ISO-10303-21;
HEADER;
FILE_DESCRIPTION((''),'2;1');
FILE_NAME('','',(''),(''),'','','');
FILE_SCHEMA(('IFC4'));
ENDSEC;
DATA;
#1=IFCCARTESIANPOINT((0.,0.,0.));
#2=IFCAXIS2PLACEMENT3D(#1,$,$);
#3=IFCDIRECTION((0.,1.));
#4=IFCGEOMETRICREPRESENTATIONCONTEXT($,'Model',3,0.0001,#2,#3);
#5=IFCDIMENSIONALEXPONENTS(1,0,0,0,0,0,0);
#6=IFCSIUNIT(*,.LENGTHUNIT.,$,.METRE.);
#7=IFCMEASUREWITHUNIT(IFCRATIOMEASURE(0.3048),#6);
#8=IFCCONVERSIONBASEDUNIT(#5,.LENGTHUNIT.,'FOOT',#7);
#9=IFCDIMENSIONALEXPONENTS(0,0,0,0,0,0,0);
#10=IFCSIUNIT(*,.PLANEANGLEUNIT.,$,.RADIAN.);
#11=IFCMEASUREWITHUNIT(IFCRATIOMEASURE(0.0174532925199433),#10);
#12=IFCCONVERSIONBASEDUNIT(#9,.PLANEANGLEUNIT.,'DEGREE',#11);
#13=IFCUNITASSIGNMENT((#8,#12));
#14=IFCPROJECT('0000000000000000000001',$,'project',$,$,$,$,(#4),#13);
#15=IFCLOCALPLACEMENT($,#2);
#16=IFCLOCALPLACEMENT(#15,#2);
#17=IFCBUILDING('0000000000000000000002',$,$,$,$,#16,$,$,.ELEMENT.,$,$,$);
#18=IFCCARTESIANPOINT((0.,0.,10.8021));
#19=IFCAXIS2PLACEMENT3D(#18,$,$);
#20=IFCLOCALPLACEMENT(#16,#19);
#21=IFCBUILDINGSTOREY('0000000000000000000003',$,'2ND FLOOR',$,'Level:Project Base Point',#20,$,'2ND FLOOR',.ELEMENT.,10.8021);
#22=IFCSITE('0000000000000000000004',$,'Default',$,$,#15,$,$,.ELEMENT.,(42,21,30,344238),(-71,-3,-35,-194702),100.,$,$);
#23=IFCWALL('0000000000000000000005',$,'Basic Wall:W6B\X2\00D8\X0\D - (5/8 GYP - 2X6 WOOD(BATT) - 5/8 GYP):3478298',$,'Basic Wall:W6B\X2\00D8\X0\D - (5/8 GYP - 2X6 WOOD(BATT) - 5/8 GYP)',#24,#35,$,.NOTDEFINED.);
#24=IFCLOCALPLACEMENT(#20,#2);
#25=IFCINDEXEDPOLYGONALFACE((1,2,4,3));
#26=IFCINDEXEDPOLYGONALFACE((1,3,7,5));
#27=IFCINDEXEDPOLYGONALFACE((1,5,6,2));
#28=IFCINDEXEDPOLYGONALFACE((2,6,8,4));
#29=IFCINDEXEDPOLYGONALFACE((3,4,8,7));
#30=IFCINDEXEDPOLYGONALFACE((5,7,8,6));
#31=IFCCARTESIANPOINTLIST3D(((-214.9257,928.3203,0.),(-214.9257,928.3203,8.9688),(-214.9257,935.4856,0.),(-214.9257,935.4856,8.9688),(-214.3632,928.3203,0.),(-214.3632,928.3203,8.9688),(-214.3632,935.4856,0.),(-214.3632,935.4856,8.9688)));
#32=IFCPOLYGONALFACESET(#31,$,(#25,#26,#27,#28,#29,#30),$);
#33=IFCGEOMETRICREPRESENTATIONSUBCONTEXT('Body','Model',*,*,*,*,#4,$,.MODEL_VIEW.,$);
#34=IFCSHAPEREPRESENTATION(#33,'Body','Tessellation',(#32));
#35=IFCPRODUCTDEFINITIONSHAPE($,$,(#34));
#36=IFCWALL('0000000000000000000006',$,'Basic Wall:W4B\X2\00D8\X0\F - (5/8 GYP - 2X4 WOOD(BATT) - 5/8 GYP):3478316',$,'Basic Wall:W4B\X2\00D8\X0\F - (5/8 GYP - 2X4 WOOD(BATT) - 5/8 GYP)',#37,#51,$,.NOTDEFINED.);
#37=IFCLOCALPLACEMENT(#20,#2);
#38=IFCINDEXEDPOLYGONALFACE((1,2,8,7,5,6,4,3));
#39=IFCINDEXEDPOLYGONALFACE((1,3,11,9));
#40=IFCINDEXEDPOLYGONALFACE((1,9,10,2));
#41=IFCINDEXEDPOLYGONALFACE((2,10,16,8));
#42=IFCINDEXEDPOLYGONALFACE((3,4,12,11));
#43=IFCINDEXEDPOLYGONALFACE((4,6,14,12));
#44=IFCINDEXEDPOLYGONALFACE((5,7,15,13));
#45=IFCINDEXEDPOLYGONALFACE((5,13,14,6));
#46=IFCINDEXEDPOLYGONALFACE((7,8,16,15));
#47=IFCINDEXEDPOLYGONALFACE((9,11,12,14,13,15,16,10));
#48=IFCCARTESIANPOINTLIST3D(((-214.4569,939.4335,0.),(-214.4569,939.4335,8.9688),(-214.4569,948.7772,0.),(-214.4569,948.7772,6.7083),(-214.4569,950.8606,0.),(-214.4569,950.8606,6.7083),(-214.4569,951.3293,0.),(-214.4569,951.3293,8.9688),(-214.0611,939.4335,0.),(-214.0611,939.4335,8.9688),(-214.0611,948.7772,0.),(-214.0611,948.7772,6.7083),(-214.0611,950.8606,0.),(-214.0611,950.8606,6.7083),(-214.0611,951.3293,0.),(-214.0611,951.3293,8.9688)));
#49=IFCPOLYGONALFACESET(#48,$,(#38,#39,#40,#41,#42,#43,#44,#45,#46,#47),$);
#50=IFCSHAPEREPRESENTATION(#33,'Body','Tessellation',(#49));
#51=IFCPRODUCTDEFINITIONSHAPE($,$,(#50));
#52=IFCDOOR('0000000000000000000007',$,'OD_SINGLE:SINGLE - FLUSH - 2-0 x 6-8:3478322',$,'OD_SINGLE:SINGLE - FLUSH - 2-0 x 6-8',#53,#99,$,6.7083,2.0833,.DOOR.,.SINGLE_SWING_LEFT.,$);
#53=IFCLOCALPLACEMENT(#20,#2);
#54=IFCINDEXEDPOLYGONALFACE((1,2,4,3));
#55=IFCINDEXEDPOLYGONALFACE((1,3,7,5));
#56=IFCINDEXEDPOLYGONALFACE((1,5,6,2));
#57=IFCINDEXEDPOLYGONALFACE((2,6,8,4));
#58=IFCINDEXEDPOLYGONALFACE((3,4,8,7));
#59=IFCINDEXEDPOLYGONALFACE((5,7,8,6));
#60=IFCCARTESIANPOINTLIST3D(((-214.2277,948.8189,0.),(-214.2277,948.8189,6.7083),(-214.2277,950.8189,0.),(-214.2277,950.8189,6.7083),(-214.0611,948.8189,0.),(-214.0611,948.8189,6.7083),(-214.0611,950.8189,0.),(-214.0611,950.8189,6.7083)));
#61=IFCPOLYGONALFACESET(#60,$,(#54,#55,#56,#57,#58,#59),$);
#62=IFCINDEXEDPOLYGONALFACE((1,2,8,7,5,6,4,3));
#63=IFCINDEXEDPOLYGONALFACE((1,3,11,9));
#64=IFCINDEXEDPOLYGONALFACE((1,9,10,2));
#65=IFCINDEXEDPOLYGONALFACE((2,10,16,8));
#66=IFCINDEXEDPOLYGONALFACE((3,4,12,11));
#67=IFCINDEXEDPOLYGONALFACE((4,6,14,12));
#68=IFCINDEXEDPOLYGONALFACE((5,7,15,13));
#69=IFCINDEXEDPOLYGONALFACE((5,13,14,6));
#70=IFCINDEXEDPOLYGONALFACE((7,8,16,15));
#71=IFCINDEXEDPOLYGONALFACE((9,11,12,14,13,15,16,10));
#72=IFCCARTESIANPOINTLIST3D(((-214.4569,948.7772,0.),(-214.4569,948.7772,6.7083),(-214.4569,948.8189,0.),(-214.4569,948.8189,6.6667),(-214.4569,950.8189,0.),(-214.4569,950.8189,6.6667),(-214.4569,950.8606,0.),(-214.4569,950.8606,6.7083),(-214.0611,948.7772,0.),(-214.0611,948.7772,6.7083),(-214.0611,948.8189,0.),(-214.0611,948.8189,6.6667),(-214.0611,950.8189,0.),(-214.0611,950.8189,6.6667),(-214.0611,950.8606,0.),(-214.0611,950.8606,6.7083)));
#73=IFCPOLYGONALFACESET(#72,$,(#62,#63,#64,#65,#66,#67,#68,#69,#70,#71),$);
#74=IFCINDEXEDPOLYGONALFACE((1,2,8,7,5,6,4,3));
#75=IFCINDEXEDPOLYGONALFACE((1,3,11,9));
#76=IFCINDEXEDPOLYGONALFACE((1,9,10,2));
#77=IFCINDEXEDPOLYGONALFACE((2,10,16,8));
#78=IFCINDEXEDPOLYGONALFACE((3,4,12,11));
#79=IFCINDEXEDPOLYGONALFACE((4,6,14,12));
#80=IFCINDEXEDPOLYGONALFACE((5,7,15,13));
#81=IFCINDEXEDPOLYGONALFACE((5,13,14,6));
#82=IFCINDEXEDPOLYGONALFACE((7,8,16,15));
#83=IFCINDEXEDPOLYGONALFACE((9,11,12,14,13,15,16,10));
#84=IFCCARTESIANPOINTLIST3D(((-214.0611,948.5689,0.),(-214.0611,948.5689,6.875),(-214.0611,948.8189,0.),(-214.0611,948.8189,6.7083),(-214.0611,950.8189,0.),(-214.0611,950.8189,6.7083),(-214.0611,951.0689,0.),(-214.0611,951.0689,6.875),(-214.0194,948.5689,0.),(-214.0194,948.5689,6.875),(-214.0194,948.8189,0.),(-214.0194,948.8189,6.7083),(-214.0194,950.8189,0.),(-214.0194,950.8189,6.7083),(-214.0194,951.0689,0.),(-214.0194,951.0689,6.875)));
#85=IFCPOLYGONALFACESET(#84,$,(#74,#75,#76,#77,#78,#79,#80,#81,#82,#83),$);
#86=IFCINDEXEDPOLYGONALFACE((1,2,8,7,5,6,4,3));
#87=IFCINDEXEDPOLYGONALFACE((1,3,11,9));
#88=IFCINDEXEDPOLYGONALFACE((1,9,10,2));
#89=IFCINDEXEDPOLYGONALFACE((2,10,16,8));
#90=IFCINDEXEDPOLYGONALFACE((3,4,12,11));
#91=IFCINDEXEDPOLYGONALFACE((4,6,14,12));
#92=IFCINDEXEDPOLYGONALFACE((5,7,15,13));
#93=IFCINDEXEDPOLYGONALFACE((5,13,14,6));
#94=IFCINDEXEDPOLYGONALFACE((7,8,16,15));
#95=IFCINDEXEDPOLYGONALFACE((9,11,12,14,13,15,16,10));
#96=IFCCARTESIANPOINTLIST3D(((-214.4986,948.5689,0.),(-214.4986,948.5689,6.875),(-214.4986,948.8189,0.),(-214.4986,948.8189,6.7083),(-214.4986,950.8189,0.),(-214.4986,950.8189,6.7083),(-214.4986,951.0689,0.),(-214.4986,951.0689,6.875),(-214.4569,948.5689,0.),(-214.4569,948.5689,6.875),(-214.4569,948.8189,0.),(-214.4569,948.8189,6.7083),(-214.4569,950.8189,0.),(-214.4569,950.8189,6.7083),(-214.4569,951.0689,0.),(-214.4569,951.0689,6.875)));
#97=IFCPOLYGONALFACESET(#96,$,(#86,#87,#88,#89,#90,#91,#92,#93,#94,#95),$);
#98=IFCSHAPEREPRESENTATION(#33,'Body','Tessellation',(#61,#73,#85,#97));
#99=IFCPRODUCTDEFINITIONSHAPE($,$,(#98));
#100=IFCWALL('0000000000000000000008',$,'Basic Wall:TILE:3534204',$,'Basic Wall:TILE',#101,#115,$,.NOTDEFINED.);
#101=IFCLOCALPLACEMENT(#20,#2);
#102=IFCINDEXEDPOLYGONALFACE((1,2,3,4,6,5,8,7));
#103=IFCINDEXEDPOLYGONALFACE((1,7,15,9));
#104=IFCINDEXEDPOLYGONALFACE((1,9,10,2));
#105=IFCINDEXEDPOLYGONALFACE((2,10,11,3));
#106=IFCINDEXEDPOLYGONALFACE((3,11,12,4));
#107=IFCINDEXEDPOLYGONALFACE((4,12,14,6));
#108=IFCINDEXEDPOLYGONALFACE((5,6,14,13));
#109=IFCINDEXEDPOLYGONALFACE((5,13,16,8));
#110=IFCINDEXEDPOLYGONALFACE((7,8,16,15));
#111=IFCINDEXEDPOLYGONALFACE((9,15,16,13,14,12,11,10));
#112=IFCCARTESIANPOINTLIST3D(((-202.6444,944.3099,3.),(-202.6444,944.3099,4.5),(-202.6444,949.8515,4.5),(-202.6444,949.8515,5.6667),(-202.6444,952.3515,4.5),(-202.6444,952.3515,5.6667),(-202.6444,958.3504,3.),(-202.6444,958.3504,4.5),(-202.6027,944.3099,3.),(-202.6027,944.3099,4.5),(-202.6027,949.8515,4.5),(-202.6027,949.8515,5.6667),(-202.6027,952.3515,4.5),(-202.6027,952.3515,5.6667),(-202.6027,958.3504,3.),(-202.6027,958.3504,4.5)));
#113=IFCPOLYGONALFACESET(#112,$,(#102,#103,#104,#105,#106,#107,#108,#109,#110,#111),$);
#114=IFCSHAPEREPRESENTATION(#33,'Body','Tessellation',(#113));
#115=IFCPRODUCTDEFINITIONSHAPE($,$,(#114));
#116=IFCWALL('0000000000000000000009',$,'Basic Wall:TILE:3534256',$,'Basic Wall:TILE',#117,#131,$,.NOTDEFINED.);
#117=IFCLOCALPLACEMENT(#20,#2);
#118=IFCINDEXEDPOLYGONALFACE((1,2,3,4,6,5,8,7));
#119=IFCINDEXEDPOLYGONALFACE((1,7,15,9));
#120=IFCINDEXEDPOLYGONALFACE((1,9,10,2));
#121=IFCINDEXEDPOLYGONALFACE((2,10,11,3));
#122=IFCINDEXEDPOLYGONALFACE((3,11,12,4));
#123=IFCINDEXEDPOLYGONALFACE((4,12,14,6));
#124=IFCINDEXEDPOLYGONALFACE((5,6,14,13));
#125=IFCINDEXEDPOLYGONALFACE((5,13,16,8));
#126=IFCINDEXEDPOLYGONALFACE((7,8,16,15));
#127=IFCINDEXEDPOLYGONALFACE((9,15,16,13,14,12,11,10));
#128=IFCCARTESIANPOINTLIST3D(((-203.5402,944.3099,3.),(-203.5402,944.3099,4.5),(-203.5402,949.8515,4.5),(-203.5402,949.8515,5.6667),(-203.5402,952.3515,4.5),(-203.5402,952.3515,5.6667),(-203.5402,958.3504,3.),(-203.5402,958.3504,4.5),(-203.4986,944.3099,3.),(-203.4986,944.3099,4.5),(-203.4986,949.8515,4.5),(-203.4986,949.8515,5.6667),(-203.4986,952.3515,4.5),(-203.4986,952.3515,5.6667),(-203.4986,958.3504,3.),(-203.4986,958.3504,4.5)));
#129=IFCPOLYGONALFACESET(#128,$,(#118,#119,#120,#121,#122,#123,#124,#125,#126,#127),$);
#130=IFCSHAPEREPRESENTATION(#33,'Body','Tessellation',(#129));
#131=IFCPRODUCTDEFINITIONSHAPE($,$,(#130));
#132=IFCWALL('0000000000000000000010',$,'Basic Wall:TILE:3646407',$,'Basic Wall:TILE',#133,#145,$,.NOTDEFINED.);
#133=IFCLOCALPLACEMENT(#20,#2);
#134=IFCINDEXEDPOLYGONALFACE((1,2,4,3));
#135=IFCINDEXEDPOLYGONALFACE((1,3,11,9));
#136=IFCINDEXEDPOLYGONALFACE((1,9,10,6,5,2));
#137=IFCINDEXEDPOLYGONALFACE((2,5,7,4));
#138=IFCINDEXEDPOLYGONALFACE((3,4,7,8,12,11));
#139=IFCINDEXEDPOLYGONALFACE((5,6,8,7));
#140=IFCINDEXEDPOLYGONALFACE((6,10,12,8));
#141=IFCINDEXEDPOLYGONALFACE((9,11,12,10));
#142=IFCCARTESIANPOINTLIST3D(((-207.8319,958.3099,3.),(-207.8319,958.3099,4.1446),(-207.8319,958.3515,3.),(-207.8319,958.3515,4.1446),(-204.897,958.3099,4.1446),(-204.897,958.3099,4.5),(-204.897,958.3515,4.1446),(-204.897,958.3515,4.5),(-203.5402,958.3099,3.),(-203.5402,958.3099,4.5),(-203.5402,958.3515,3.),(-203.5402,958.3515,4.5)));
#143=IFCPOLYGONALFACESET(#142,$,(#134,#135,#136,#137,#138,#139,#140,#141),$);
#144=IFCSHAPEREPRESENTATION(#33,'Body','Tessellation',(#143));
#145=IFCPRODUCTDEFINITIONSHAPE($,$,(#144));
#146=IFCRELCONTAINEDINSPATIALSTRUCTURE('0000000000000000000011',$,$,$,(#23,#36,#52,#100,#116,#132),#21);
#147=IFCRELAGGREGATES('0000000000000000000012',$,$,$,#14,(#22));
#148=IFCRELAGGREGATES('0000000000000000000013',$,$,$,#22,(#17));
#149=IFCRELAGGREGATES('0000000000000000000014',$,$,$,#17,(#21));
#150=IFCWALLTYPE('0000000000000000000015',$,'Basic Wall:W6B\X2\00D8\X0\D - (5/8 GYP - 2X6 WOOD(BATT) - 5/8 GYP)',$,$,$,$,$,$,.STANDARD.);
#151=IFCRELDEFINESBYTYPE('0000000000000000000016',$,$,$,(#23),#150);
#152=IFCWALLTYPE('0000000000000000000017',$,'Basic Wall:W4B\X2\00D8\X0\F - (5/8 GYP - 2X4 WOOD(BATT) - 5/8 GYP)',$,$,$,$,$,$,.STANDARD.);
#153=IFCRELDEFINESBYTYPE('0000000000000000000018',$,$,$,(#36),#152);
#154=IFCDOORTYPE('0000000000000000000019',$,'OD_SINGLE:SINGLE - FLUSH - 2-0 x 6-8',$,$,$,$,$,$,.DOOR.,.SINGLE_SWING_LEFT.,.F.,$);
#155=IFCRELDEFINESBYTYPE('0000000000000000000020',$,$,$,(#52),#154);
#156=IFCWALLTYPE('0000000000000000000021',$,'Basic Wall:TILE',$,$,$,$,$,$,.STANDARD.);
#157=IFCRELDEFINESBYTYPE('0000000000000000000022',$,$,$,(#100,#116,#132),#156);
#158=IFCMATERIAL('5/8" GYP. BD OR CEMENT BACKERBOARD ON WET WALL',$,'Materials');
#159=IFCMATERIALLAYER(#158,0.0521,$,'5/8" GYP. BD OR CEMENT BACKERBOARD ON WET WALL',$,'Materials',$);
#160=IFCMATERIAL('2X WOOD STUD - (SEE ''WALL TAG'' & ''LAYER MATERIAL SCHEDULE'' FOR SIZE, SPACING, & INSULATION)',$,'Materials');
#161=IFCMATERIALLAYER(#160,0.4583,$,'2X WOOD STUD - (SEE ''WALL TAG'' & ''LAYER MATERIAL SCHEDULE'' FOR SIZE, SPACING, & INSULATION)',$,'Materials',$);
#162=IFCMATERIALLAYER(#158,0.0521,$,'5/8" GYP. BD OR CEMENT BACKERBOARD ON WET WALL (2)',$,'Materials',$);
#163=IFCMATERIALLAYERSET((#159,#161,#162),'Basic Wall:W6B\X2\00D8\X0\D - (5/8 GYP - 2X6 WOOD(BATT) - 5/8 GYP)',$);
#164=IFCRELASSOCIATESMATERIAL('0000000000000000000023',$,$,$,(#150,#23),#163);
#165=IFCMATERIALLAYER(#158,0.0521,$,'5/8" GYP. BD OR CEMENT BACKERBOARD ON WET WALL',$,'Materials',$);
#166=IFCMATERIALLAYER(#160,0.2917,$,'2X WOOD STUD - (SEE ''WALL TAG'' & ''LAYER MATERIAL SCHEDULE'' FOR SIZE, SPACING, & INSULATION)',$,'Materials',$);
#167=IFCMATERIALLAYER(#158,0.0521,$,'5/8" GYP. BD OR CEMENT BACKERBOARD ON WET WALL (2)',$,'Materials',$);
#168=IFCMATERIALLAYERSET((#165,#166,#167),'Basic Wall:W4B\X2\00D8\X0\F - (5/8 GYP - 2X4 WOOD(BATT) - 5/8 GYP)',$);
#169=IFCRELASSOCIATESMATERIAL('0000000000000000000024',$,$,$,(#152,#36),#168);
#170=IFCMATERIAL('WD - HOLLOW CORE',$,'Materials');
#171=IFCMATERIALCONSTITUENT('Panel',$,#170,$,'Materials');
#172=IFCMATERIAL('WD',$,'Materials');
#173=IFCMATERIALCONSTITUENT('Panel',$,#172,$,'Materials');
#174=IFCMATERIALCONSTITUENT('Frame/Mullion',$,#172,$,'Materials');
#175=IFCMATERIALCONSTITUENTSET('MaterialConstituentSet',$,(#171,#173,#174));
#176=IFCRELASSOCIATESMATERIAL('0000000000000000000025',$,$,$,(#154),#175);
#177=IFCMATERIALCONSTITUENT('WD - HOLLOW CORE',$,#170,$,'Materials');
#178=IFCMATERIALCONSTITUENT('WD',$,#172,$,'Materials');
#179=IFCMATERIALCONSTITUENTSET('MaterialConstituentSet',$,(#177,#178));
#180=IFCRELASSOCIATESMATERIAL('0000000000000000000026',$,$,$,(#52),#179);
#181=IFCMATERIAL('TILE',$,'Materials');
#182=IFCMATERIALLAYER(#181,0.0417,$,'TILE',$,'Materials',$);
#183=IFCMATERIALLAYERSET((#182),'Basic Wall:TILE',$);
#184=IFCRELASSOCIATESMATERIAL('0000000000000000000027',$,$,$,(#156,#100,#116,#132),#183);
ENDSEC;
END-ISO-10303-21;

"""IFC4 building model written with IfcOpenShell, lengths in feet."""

from ifc_helpers import new_model, entity, si_unit, converted_unit, direction, frame, frame_2d, origin, origin_2d_with_axis, place, context, subcontext, project, spatial, polyline, rectangle, outline, extrude, source, transform, mapped, material, layer, layer_set, layer_usage, constituent, constituent_set, type_object, type_shapes, element, fill, save


model = new_model("IFC4")

# Units and contexts
model_context = context("Model", 3, precision=0.0001, world=origin(), true_north=direction((0.0, 1.0)))
body_context = subcontext(model_context, "Body", "Model", "MODEL_VIEW")
ifc_project = project(units=[converted_unit("LENGTHUNIT", "FOOT", entity("IfcRatioMeasure", 0.3048), si_unit("LENGTHUNIT", "METRE"), dimensions=[1, 0, 0, 0, 0, 0, 0]), converted_unit("PLANEANGLEUNIT", "DEGREE", entity("IfcRatioMeasure", 0.0174532925199433), si_unit("PLANEANGLEUNIT", "RADIAN"), dimensions=[0, 0, 0, 0, 0, 0, 0])], contexts=[model_context])

# Site, building, storey
site_placement = place(None, origin())
site = spatial("IfcSite", under=ifc_project, at=site_placement, Name="Default", CompositionType="ELEMENT", RefLatitude=(42, 21, 30, 344238), RefLongitude=(-71, -3, -35, -194702), RefElevation=100.0)
building_placement = place(site_placement, origin())
building = spatial("IfcBuilding", under=site, at=building_placement, CompositionType="ELEMENT")
storey_placement = place(building_placement, frame((0.0, 0.0, 10.8021)))
storey = spatial("IfcBuildingStorey", under=building, at=storey_placement, Name="2ND FLOOR", ObjectType="Level:Project Base Point", LongName="2ND FLOOR", CompositionType="ELEMENT", Elevation=10.8021)

# Wall
ifc_material_1 = material(Name="5/8\" GYP. BD OR CEMENT BACKERBOARD ON WET WALL", Category="Materials")
ifc_layer_1 = layer(ifc_material_1, 0.0521, Name="5/8\" GYP. BD OR CEMENT BACKERBOARD ON WET WALL", Category="Materials")
ifc_material_2 = material(Name="2X WOOD STUD - (SEE 'WALL TAG' & 'LAYER MATERIAL SCHEDULE' FOR SIZE, SPACING, & INSULATION)", Category="Materials")
ifc_layer_2 = layer(ifc_material_2, 0.4583, Name="2X WOOD STUD - (SEE 'WALL TAG' & 'LAYER MATERIAL SCHEDULE' FOR SIZE, SPACING, & INSULATION)", Category="Materials")
ifc_layer_3 = layer(ifc_material_1, 0.0521, Name="5/8\" GYP. BD OR CEMENT BACKERBOARD ON WET WALL (2)", Category="Materials")
ifc_layer_set_1 = layer_set([ifc_layer_1, ifc_layer_2, ifc_layer_3], Name="Basic Wall:W6BØD - (5/8 GYP - 2X6 WOOD(BATT) - 5/8 GYP)")
ifc_layer_usage_1 = layer_usage(ifc_layer_set_1, "AXIS2", "POSITIVE", -0.2812)
wall_type_1 = type_object("IfcWallType", Name="Basic Wall:W6BØD - (5/8 GYP - 2X6 WOOD(BATT) - 5/8 GYP)", PredefinedType="STANDARD", material=ifc_layer_set_1)
wall_1_placement = place(storey_placement, frame((-214.6444, 928.3203, 0.0), z_axis=(0.0, 0.0, 1.0), x_axis=(0.0, 1.0, 0.0)))
element("IfcWall", 1, at=wall_1_placement, inside=storey, type_object=wall_type_1, material=ifc_layer_usage_1, Name="Basic Wall:W6BØD - (5/8 GYP - 2X6 WOOD(BATT) - 5/8 GYP):3478298", ObjectType="Basic Wall:W6BØD - (5/8 GYP - 2X6 WOOD(BATT) - 5/8 GYP)", PredefinedType="NOTDEFINED", context=body_context, shape_type="SweptSolid", body=[
    extrude(rectangle(XDim=7.1653, YDim=0.5625, at=frame_2d((3.5826, 0.0), x_axis=(-1.0, 0.0))), origin(), (0.0, 0.0, 1.0), 8.9688),
])

# Wall, opening, door
ifc_layer_4 = layer(ifc_material_1, 0.0521, Name="5/8\" GYP. BD OR CEMENT BACKERBOARD ON WET WALL", Category="Materials")
ifc_layer_5 = layer(ifc_material_2, 0.2917, Name="2X WOOD STUD - (SEE 'WALL TAG' & 'LAYER MATERIAL SCHEDULE' FOR SIZE, SPACING, & INSULATION)", Category="Materials")
ifc_layer_6 = layer(ifc_material_1, 0.0521, Name="5/8\" GYP. BD OR CEMENT BACKERBOARD ON WET WALL (2)", Category="Materials")
ifc_layer_set_2 = layer_set([ifc_layer_4, ifc_layer_5, ifc_layer_6], Name="Basic Wall:W4BØF - (5/8 GYP - 2X4 WOOD(BATT) - 5/8 GYP)")
wall_type_2 = type_object("IfcWallType", Name="Basic Wall:W4BØF - (5/8 GYP - 2X4 WOOD(BATT) - 5/8 GYP)", PredefinedType="STANDARD", material=ifc_layer_set_2)
ifc_material_3 = material(Name="WD - HOLLOW CORE", Category="Materials")
ifc_material_4 = material(Name="WD", Category="Materials")
ifc_layer_usage_2 = layer_usage(ifc_layer_set_2, "AXIS2", "POSITIVE", -0.1979)
wall_2_placement = place(storey_placement, frame((-214.259, 939.4335, 0.0), z_axis=(0.0, 0.0, 1.0), x_axis=(0.0, 1.0, 0.0)))
wall_2 = element("IfcWall", 2, at=wall_2_placement, inside=storey, type_object=wall_type_2, material=ifc_layer_usage_2, Name="Basic Wall:W4BØF - (5/8 GYP - 2X4 WOOD(BATT) - 5/8 GYP):3478316", ObjectType="Basic Wall:W4BØF - (5/8 GYP - 2X4 WOOD(BATT) - 5/8 GYP)", PredefinedType="NOTDEFINED", context=body_context, shape_type="SweptSolid", body=[
    extrude(rectangle(XDim=11.8958, YDim=0.3958, at=frame_2d((5.9479, 0.0), x_axis=(-1.0, 0.0))), origin(), (0.0, 0.0, 1.0), 8.9688),
])
opening_1_placement = place(wall_2_placement, frame((11.4271, 0.1979, 0.0)))
opening_1 = element("IfcOpeningElement", 3, at=opening_1_placement, cuts=wall_2, PredefinedType="OPENING", context=body_context, shape_type="SweptSolid", body=[
    extrude(rectangle(XDim=2.0833, YDim=6.7083, at=frame_2d((3.3542, 1.0417), x_axis=(0.0, -1.0))), frame((0.0, 0.0, 0.0), z_axis=(0.0, -1.0, 0.0), x_axis=(0.0, 0.0, 1.0)), (0.0, 0.0, 1.0), 0.3958),
])
ifc_constituent_1 = constituent(ifc_material_3, Name="WD - HOLLOW CORE", Category="Materials")
ifc_constituent_2 = constituent(ifc_material_4, Name="WD", Category="Materials")
ifc_constituent_set_1 = constituent_set(constituents=[ifc_constituent_1, ifc_constituent_2], Name="MaterialConstituentSet")
ifc_constituent_3 = constituent(ifc_material_3, Name="Panel", Category="Materials")
ifc_constituent_4 = constituent(ifc_material_4, Name="Panel", Category="Materials")
ifc_constituent_5 = constituent(ifc_material_4, Name="Frame/Mullion", Category="Materials")
ifc_constituent_set_2 = constituent_set(constituents=[ifc_constituent_3, ifc_constituent_4, ifc_constituent_5], Name="MaterialConstituentSet")
door_type_1 = type_object("IfcDoorType", Name="OD_SINGLE:SINGLE - FLUSH - 2-0 x 6-8", OperationType="SINGLE_SWING_LEFT", ParameterTakesPrecedence=False, PredefinedType="DOOR", material=ifc_constituent_set_2)
shared_shape_1 = source(origin(), body_context, "Body", "SweptSolid", [
    extrude(rectangle(XDim=2.0, YDim=0.1667, at=origin_2d_with_axis()), frame((1.0417, 0.3125, 0.0)), (0.0, 0.0, 1.0), 6.7083),
    extrude(outline(polyline([(-3.3646, -1.0417), (3.3438, -1.0417), (3.3438, -1.0), (-3.3229, -1.0), (-3.3229, 1.0), (3.3438, 1.0), (3.3438, 1.0417), (-3.3646, 1.0417), (-3.3646, -1.0417)])), frame((1.0417, 0.3958, 3.3438), z_axis=(0.0, -1.0, 0.0), x_axis=(0.0, 0.0, -1.0)), (0.0, 0.0, 1.0), 0.3958),
    extrude(outline(polyline([(-1.25, -3.4792), (1.25, -3.4792), (1.25, 3.3958), (1.0, 3.3958), (1.0, -3.3125), (-1.0, -3.3125), (-1.0, 3.3958), (-1.25, 3.3958), (-1.25, -3.4792)])), frame((1.0417, 0.4375, 3.3958), z_axis=(0.0, -1.0, 0.0), x_axis=(-1.0, 0.0, 0.0)), (0.0, 0.0, 1.0), 0.0417),
    extrude(outline(polyline([(-3.4792, -1.25), (3.3958, -1.25), (3.3958, -1.0), (-3.3125, -1.0), (-3.3125, 1.0), (3.3958, 1.0), (3.3958, 1.25), (-3.4792, 1.25), (-3.4792, -1.25)])), frame((1.0417, 0.0, 3.3958), z_axis=(0.0, -1.0, 0.0), x_axis=(0.0, 0.0, -1.0)), (0.0, 0.0, 1.0), 0.0417),
])
type_shapes(door_type_1, [shared_shape_1])
door_1_placement = place(opening_1_placement, frame((0.0, 0.0, 0.0), z_axis=(0.0, 0.0, 1.0), x_axis=(-1.0, 0.0, 0.0)))
door_1 = element("IfcDoor", 4, at=door_1_placement, inside=storey, type_object=door_type_1, material=ifc_constituent_set_1, Name="OD_SINGLE:SINGLE - FLUSH - 2-0 x 6-8:3478322", ObjectType="OD_SINGLE:SINGLE - FLUSH - 2-0 x 6-8", OperationType="SINGLE_SWING_LEFT", OverallHeight=6.7083, OverallWidth=2.0833, PredefinedType="DOOR", context=body_context, shape_type="MappedRepresentation", body=[
    mapped(shared_shape_1, transform((0.0, 0.0, 0.0), scale=1.0)),
])
fill(opening_1, door_1)

# Walls, openings
ifc_material_5 = material(Name="TILE", Category="Materials")
ifc_layer_7 = layer(ifc_material_5, 0.0417, Name="TILE", Category="Materials")
ifc_layer_set_3 = layer_set([ifc_layer_7], Name="Basic Wall:TILE")
ifc_layer_usage_3 = layer_usage(ifc_layer_set_3, "AXIS2", "POSITIVE", -0.0208)
wall_type_3 = type_object("IfcWallType", Name="Basic Wall:TILE", PredefinedType="STANDARD", material=ifc_layer_set_3)
wall_3_placement = place(storey_placement, frame((-202.6236, 958.3504, 3.0), z_axis=(0.0, 0.0, 1.0), x_axis=(0.0, -1.0, 0.0)))
wall_3 = element("IfcWall", 5, at=wall_3_placement, inside=storey, type_object=wall_type_3, material=ifc_layer_usage_3, Name="Basic Wall:TILE:3534204", ObjectType="Basic Wall:TILE", PredefinedType="NOTDEFINED", context=body_context, shape_type="SweptSolid", body=[
    extrude(rectangle(XDim=14.0406, YDim=0.0417, at=frame_2d((7.0203, 0.0), x_axis=(-1.0, 0.0))), origin(), (0.0, 0.0, 1.0), 2.6667),
])
opening_2_placement = place(wall_3_placement, origin())
element("IfcOpeningElement", 6, at=opening_2_placement, cuts=wall_3, PredefinedType="OPENING", context=body_context, shape_type="SweptSolid", body=[
    extrude(rectangle(XDim=1.1667, YDim=5.5417, at=frame_2d((0.0, 0.0), x_axis=(1.0, 0.0))), frame((11.2697, 0.0208, 2.0833), z_axis=(0.0, -1.0, 0.0), x_axis=(0.0, 0.0, 1.0)), (0.0, 0.0, 1.0), 0.0417),
])
opening_3_placement = place(wall_3_placement, origin())
element("IfcOpeningElement", 7, at=opening_3_placement, cuts=wall_3, PredefinedType="OPENING", context=body_context, shape_type="SweptSolid", body=[
    extrude(rectangle(XDim=1.1667, YDim=5.9989, at=frame_2d((0.0, 0.0), x_axis=(0.0, 1.0))), frame((2.9994, 0.0208, 2.0833), z_axis=(0.0, -1.0, 0.0), x_axis=(-1.0, 0.0, 0.0)), (0.0, 0.0, 1.0), 0.0417),
])
ifc_layer_usage_4 = layer_usage(ifc_layer_set_3, "AXIS2", "NEGATIVE", 0.0208)
wall_4_placement = place(storey_placement, frame((-203.5194, 958.3504, 3.0), z_axis=(0.0, 0.0, 1.0), x_axis=(0.0, -1.0, 0.0)))
wall_4 = element("IfcWall", 8, at=wall_4_placement, inside=storey, type_object=wall_type_3, material=ifc_layer_usage_4, Name="Basic Wall:TILE:3534256", ObjectType="Basic Wall:TILE", PredefinedType="NOTDEFINED", context=body_context, shape_type="SweptSolid", body=[
    extrude(rectangle(XDim=14.0406, YDim=0.0417, at=frame_2d((7.0203, 0.0), x_axis=(-1.0, 0.0))), origin(), (0.0, 0.0, 1.0), 2.6667),
])
opening_4_placement = place(wall_4_placement, origin())
element("IfcOpeningElement", 9, at=opening_4_placement, cuts=wall_4, PredefinedType="OPENING", context=body_context, shape_type="SweptSolid", body=[
    extrude(rectangle(XDim=1.1667, YDim=5.5417, at=frame_2d((0.0, 0.0), x_axis=(1.0, 0.0))), frame((11.2697, 0.0208, 2.0833), z_axis=(0.0, -1.0, 0.0), x_axis=(0.0, 0.0, 1.0)), (0.0, 0.0, 1.0), 0.0417),
])
opening_5_placement = place(wall_4_placement, origin())
element("IfcOpeningElement", 10, at=opening_5_placement, cuts=wall_4, PredefinedType="OPENING", context=body_context, shape_type="SweptSolid", body=[
    extrude(rectangle(XDim=1.1667, YDim=5.9989, at=frame_2d((0.0, 0.0), x_axis=(0.0, 1.0))), frame((2.9994, 0.0208, 2.0833), z_axis=(0.0, -1.0, 0.0), x_axis=(-1.0, 0.0, 0.0)), (0.0, 0.0, 1.0), 0.0417),
])

# Wall, opening
ifc_layer_usage_5 = layer_usage(ifc_layer_set_3, "AXIS2", "POSITIVE", -0.0208)
wall_5_placement = place(storey_placement, frame((-203.5402, 958.3307, 3.0), z_axis=(0.0, 0.0, 1.0), x_axis=(-1.0, 0.0, 0.0)))
wall_5 = element("IfcWall", 11, at=wall_5_placement, inside=storey, type_object=wall_type_3, material=ifc_layer_usage_5, Name="Basic Wall:TILE:3646407", ObjectType="Basic Wall:TILE", PredefinedType="NOTDEFINED", context=body_context, shape_type="SweptSolid", body=[
    extrude(rectangle(XDim=4.2917, YDim=0.0417, at=frame_2d((2.1458, 0.0), x_axis=(-1.0, 0.0))), origin(), (0.0, 0.0, 1.0), 1.5),
])
opening_6_placement = place(wall_5_placement, origin())
element("IfcOpeningElement", 12, at=opening_6_placement, cuts=wall_5, PredefinedType="OPENING", context=body_context, shape_type="SweptSolid", body=[
    extrude(rectangle(XDim=0.3554, YDim=2.9349, at=frame_2d((0.0, 0.0), x_axis=(1.0, 0.0))), frame((2.8242, 0.0208, 1.3223), z_axis=(0.0, -1.0, 0.0), x_axis=(0.0, 0.0, 1.0)), (0.0, 0.0, 1.0), 0.0417),
])

save(model, "model.ifc")
